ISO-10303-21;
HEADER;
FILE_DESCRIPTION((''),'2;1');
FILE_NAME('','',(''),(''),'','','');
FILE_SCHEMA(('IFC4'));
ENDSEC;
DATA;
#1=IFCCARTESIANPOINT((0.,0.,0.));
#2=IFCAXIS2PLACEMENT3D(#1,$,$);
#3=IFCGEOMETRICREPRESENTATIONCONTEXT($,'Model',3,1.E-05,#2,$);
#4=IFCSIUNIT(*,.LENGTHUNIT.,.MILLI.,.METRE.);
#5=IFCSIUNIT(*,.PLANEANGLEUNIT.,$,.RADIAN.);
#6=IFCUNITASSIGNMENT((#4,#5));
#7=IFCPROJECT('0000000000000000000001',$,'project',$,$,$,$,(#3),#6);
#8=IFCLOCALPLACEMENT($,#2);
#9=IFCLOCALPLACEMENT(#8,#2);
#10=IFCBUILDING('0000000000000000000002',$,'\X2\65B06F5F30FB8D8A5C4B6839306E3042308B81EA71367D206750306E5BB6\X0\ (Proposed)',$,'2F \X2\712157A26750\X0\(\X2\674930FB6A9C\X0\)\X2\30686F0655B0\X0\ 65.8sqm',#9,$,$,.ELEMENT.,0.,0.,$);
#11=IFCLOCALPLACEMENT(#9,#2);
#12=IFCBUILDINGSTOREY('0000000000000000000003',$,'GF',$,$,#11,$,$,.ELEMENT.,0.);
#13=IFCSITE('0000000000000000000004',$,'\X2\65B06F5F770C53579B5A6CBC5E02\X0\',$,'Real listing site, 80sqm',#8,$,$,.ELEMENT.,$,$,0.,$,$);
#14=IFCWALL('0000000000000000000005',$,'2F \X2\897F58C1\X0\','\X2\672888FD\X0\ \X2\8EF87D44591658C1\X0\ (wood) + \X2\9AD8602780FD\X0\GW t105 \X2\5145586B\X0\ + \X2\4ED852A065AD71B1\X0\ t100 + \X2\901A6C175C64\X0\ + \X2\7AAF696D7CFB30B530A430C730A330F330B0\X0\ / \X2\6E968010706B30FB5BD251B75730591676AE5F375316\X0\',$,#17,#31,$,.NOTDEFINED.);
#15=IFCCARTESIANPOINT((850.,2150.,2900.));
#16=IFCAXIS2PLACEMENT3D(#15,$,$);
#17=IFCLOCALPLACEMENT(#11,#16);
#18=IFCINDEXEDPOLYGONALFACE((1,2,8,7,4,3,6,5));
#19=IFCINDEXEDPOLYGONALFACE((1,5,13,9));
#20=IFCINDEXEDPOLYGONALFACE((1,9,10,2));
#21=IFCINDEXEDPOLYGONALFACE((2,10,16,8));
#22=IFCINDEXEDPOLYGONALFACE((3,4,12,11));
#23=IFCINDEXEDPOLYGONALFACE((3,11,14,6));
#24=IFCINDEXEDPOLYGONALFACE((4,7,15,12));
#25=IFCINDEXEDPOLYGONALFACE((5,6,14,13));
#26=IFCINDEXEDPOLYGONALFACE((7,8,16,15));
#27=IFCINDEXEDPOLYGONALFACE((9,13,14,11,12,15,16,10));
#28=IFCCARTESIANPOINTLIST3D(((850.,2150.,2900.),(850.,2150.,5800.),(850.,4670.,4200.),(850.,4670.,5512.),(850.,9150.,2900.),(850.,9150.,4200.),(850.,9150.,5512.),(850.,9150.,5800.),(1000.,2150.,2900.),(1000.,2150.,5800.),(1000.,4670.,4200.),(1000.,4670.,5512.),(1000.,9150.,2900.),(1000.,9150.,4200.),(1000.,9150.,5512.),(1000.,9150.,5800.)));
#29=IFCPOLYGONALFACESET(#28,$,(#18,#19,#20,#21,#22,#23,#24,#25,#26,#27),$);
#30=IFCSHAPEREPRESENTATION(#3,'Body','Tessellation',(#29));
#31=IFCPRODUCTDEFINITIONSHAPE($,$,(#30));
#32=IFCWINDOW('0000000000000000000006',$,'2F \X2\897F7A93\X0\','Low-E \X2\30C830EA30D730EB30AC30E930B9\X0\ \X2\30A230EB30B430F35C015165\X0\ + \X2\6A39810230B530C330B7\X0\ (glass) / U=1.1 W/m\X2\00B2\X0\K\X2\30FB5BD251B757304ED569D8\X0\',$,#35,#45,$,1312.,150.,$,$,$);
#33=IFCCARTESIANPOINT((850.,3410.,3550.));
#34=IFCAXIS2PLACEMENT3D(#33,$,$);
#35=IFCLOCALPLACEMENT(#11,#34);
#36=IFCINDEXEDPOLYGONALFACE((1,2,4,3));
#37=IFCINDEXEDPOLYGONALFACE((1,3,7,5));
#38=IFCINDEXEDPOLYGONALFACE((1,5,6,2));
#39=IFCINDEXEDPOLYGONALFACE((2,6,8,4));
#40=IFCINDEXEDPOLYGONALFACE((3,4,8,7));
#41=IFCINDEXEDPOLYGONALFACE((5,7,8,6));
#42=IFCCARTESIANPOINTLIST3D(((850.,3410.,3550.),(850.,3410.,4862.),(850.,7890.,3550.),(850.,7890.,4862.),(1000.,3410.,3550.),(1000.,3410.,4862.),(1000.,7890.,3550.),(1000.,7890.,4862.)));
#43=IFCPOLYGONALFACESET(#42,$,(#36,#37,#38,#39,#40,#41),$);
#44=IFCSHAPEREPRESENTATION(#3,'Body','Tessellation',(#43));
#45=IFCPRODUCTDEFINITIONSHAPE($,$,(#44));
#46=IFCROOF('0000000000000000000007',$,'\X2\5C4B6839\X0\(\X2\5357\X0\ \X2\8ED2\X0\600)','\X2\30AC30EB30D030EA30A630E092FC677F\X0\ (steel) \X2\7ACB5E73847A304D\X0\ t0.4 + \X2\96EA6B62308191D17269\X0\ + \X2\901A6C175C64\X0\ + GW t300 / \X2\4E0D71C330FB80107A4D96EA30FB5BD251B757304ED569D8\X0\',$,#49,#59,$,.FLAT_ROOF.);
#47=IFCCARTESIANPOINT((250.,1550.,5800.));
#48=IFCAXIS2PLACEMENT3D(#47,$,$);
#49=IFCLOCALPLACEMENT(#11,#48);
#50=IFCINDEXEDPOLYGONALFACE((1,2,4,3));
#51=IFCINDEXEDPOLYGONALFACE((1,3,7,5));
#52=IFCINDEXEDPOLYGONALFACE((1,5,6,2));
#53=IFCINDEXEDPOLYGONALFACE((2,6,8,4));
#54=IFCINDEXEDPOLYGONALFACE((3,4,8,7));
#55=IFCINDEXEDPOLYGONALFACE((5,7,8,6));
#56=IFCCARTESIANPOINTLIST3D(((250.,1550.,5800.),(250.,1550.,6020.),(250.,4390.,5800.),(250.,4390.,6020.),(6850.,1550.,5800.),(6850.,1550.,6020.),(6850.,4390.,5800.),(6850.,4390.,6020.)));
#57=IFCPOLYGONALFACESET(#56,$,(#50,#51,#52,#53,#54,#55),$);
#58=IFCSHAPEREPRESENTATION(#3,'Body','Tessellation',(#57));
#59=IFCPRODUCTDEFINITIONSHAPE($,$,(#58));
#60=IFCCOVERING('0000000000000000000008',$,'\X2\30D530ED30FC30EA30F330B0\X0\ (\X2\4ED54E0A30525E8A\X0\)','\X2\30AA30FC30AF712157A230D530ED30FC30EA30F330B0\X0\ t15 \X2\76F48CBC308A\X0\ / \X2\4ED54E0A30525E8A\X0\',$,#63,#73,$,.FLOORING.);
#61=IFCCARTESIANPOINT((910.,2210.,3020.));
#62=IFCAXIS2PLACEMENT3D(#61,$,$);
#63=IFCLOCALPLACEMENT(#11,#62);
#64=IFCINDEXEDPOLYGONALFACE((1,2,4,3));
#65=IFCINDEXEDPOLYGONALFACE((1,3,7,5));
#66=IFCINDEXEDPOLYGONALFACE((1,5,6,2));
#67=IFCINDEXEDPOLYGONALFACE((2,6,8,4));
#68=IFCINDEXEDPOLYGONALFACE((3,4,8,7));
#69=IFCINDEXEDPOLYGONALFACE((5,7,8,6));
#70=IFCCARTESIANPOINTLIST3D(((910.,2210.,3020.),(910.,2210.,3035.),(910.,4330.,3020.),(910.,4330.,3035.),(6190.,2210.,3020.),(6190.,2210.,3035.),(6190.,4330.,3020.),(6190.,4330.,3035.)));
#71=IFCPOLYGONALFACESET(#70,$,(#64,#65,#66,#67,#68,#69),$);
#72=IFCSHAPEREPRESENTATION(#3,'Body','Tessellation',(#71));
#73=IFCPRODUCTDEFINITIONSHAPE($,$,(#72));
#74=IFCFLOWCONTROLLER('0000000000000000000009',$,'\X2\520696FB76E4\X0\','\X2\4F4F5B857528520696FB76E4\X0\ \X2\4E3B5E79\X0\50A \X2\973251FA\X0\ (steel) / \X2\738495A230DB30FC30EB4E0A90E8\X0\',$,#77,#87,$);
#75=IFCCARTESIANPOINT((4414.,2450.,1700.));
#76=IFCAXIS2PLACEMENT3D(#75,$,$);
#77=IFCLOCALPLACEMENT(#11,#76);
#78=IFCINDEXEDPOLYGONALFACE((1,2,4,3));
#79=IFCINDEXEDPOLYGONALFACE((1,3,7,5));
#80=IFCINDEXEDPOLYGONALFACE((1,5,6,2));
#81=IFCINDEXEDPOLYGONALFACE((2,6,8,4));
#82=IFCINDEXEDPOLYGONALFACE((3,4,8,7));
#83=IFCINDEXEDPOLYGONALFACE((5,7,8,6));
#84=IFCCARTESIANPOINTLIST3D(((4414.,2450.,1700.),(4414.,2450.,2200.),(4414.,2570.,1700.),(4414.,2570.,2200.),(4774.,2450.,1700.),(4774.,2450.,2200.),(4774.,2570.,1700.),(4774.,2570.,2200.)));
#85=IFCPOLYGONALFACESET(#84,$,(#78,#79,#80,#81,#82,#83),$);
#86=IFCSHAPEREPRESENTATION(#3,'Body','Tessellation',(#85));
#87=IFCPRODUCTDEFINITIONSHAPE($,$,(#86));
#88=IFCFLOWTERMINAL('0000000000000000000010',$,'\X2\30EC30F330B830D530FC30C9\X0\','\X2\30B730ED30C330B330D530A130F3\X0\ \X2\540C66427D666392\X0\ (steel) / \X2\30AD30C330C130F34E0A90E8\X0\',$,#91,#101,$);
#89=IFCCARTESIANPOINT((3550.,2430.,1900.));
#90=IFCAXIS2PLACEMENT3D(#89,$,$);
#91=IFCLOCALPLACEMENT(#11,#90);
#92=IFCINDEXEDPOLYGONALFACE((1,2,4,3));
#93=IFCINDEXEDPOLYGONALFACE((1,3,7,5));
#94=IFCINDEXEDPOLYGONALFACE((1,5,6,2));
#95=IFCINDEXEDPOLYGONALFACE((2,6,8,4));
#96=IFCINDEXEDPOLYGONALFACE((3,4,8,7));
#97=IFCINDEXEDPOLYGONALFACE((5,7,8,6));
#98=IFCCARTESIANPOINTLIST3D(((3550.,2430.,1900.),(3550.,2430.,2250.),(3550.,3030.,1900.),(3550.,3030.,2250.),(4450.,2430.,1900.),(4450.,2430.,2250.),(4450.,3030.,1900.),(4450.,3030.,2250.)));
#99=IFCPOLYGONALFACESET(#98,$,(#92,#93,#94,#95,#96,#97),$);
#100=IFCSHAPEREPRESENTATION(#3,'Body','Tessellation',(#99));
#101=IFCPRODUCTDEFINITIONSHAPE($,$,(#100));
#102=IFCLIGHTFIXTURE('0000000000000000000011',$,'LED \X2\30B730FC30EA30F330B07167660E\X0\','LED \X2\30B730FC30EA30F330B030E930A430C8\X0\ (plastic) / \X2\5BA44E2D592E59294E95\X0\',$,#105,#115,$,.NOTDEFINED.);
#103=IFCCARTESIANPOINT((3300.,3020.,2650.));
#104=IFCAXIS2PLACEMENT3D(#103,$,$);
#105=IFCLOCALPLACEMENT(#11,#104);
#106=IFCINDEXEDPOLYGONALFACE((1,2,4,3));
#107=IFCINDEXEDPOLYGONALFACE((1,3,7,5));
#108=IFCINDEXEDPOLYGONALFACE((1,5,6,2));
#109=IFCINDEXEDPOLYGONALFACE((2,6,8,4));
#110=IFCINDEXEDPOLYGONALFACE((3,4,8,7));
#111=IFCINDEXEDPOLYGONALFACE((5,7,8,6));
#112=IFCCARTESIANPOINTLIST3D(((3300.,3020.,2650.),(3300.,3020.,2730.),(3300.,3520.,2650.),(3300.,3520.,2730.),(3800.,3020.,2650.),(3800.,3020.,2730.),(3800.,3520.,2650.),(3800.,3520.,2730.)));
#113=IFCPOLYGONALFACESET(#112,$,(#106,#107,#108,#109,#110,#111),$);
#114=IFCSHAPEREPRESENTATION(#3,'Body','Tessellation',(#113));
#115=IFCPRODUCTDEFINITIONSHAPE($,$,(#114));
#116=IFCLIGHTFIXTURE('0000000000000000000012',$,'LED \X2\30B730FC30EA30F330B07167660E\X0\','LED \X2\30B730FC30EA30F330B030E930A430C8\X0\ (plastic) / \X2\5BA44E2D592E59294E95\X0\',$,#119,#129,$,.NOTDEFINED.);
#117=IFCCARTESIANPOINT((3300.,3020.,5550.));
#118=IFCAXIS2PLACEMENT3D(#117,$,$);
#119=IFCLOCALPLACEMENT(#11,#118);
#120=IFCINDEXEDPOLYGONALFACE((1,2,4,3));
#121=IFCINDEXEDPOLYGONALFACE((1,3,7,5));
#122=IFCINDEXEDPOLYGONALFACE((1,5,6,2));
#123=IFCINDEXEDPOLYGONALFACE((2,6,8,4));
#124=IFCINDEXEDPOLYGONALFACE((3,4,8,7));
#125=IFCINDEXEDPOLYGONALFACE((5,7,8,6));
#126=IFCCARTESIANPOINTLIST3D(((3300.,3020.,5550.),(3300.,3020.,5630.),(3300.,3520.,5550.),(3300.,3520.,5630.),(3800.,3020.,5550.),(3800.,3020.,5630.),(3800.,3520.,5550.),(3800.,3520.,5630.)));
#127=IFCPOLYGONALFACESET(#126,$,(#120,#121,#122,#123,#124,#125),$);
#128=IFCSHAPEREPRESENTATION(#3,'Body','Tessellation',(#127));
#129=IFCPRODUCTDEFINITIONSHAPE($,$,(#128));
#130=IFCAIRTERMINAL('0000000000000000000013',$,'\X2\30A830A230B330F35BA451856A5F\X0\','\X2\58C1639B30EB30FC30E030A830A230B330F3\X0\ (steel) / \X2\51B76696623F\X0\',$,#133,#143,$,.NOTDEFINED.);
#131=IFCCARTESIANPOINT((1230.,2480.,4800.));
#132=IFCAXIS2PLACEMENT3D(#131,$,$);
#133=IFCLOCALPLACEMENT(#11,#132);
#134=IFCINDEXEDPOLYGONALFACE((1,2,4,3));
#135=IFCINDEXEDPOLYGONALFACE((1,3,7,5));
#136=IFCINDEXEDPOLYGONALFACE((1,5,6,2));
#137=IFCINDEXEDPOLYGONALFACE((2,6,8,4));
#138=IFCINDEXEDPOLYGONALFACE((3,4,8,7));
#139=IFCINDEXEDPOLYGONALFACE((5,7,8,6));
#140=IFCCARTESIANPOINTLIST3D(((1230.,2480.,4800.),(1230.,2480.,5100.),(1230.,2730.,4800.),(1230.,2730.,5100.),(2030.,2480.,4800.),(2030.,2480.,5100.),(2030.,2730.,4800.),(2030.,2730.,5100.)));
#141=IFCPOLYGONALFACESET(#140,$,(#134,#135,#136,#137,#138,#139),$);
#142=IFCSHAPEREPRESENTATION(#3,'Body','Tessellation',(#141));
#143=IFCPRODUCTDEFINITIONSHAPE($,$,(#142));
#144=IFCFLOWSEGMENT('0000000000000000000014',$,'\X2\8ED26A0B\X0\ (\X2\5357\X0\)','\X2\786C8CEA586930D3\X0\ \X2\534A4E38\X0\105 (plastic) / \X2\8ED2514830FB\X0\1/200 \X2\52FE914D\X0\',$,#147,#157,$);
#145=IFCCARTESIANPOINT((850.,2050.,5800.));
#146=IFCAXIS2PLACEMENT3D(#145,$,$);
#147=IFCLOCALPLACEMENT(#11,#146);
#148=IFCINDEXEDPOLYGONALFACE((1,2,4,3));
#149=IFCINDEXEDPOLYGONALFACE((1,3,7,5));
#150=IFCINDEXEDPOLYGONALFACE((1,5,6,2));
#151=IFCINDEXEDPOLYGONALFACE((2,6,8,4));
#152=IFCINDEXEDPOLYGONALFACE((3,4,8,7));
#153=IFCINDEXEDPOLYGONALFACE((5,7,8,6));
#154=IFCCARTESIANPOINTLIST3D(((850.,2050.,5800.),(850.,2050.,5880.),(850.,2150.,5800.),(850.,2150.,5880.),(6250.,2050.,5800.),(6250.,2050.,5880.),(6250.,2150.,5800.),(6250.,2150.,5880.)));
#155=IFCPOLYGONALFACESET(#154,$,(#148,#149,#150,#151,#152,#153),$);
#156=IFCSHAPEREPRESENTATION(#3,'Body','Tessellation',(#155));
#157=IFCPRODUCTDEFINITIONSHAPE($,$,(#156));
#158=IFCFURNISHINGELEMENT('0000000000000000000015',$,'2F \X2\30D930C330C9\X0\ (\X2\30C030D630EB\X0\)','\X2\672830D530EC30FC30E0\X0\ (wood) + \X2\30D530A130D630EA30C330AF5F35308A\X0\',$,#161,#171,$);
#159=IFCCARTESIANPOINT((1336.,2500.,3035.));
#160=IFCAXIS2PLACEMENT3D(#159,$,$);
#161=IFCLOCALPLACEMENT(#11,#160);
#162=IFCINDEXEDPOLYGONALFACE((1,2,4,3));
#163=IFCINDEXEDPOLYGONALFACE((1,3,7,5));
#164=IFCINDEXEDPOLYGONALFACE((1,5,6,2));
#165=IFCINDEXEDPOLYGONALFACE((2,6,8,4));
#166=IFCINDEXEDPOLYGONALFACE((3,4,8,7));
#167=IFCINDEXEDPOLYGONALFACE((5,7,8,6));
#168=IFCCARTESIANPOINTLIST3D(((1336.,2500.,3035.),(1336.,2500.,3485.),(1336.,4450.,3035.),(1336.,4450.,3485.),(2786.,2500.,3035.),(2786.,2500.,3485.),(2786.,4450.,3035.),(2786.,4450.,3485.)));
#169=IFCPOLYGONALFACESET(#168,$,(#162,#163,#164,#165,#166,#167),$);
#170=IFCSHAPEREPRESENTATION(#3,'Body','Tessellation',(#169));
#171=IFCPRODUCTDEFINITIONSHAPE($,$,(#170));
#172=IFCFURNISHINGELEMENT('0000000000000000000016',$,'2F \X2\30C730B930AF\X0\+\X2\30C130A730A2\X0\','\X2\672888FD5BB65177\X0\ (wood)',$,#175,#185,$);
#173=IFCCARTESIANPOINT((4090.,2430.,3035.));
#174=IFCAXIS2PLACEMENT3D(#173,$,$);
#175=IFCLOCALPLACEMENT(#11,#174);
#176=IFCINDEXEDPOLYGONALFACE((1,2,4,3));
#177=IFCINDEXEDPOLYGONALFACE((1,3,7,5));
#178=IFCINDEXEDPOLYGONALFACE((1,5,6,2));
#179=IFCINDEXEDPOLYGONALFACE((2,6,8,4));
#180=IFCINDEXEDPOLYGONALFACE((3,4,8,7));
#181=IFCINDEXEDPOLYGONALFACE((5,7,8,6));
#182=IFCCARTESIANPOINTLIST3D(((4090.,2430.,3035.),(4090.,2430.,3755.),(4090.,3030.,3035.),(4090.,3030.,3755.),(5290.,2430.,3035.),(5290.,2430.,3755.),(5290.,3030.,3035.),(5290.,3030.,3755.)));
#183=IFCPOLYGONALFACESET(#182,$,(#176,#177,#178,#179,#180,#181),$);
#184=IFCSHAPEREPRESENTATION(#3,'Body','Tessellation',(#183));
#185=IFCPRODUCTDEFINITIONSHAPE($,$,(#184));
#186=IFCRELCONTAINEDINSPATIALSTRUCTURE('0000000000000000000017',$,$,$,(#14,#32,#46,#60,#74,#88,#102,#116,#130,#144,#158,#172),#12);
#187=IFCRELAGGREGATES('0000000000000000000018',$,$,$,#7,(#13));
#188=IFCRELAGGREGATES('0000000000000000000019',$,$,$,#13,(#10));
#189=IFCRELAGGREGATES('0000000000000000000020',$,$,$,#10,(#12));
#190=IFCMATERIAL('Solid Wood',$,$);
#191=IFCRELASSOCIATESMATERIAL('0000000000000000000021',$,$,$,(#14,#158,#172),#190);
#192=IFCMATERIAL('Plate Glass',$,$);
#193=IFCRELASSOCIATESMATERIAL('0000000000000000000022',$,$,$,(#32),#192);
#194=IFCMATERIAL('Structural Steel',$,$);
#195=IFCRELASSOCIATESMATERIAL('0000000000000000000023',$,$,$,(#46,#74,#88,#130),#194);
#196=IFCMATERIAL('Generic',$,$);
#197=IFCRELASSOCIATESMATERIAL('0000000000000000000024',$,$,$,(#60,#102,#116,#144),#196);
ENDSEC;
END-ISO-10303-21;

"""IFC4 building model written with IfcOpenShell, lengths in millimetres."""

from ifc_helpers import new_model, si_unit, frame, frame_2d, origin, place, context, project, spatial, rectangle, extrude, material, element, fill, save


model = new_model("IFC4")

# Units and contexts
model_context = context("Model", 3, precision=1e-05, world=origin())
ifc_project = project(units=[si_unit("LENGTHUNIT", "METRE", prefix="MILLI"), si_unit("PLANEANGLEUNIT", "RADIAN")], contexts=[model_context])

# Site, building, storey
site_placement = place(None, origin())
site = spatial("IfcSite", under=ifc_project, at=site_placement, Name="新潟県南魚沼市", ObjectType="Real listing site, 80sqm", CompositionType="ELEMENT", RefElevation=0.0)
building_placement = place(site_placement, origin())
building = spatial("IfcBuilding", under=site, at=building_placement, Name="新潟・越屋根のある自然素材の家 (Proposed)", ObjectType="2F 無垢材(杉・檜)と漆喰 65.8sqm", CompositionType="ELEMENT", ElevationOfRefHeight=0.0, ElevationOfTerrain=0.0)
storey_placement = place(building_placement, origin())
storey = spatial("IfcBuildingStorey", under=building, at=storey_placement, Name="GF", CompositionType="ELEMENT", Elevation=0.0)

# Shared definitions
ifc_material_1 = material(Name="Solid Wood")

# Wall, opening, window
ifc_material_2 = material(Name="Plate Glass")
wall_1_placement = place(storey_placement, frame((850.0, 2150.0, 2900.0)))
wall_1 = element("IfcWall", 1, at=wall_1_placement, inside=storey, material=ifc_material_1, Name="2F 西壁", Description="木製 軸組外壁 (wood) + 高性能GW t105 充填 + 付加断熱 t100 + 通気層 + 窯業系サイディング / 準耐火・寒冷地外皮強化", PredefinedType="NOTDEFINED", context=model_context, shape_type="SweptSolid", body=[
    extrude(rectangle(XDim=150.0, YDim=7000.0, at=frame_2d((75.0, 3500.0))), frame((850.0, 2150.0, 2900.0)), (0.0, 0.0, 1.0), 2900.0),
])
opening_1_placement = place(storey_placement, frame((850.0, 3410.0, 3550.0)))
opening_1 = element("IfcOpeningElement", 2, at=opening_1_placement, cuts=wall_1, PredefinedType="NOTDEFINED", context=model_context, shape_type="SweptSolid", body=[
    extrude(rectangle(XDim=150.0, YDim=4480.0, at=frame_2d((75.0, 2240.0))), frame((850.0, 3410.0, 3550.0)), (0.0, 0.0, 1.0), 1312.0),
])
window_1_placement = place(storey_placement, frame((850.0, 3410.0, 3550.0)))
window_1 = element("IfcWindow", 3, at=window_1_placement, inside=storey, material=ifc_material_2, Name="2F 西窓", Description="Low-E トリプルガラス アルゴン封入 + 樹脂サッシ (glass) / U=1.1 W/m²K・寒冷地仕様", OverallHeight=1312.0, OverallWidth=150.0, context=model_context, shape_type="SweptSolid", body=[
    extrude(rectangle(XDim=150.0, YDim=4480.0, at=frame_2d((75.0, 2240.0))), frame((850.0, 3410.0, 3550.0)), (0.0, 0.0, 1.0), 1312.0),
])
fill(opening_1, window_1)

# Roof
ifc_material_3 = material(Name="Structural Steel")
for number, where, name in (
    (4, (250.0, 1550.0, 5800.0), "屋根(南 軒600)"),
):
    element("IfcRoof", number, at=place(storey_placement, frame(where)), inside=storey, material=ifc_material_3, Name=name, Description="ガルバリウム鋼板 (steel) 立平葺き t0.4 + 雪止め金物 + 通気層 + GW t300 / 不燃・耐積雪・寒冷地仕様", PredefinedType="FLAT_ROOF", context=model_context, shape_type="SweptSolid", body=[
        extrude(rectangle(XDim=6600.0, YDim=2840.0, at=frame_2d((3300.0, 1420.0))), frame((250.0, 1550.0, 5800.0)), (0.0, 0.0, 1.0), 220.0),
    ])

# Covering
ifc_material_4 = material(Name="Generic")
covering_placement = place(storey_placement, frame((910.0, 2210.0, 3020.0)))
element("IfcCovering", 5, at=covering_placement, inside=storey, material=ifc_material_4, Name="フローリング (仕上げ床)", Description="オーク無垢フローリング t15 直貼り / 仕上げ床", PredefinedType="FLOORING", context=model_context, shape_type="SweptSolid", body=[
    extrude(rectangle(XDim=5280.0, YDim=2120.0, at=frame_2d((2640.0, 1060.0))), frame((910.0, 2210.0, 3020.0)), (0.0, 0.0, 1.0), 15.0),
])

# Flow controller
flow_controller_placement = place(storey_placement, frame((4414.0, 2450.0, 1700.0)))
element("IfcFlowController", 6, at=flow_controller_placement, inside=storey, material=ifc_material_3, Name="分電盤", Description="住宅用分電盤 主幹50A 露出 (steel) / 玄関ホール上部", context=model_context, shape_type="SweptSolid", body=[
    extrude(rectangle(XDim=360.0, YDim=120.0, at=frame_2d((180.0, 60.0))), frame((4414.0, 2450.0, 1700.0)), (0.0, 0.0, 1.0), 500.0),
])

# Flow terminal
flow_terminal_placement = place(storey_placement, frame((3550.0, 2430.0, 1900.0)))
element("IfcFlowTerminal", 7, at=flow_terminal_placement, inside=storey, material=ifc_material_3, Name="レンジフード", Description="シロッコファン 同時給排 (steel) / キッチン上部", context=model_context, shape_type="SweptSolid", body=[
    extrude(rectangle(XDim=900.0, YDim=600.0, at=frame_2d((450.0, 300.0))), frame((3550.0, 2430.0, 1900.0)), (0.0, 0.0, 1.0), 350.0),
])

# Light fixtures
light_fixture_1_placement = place(storey_placement, frame((3300.0, 3020.0, 2650.0)))
element("IfcLightFixture", 8, at=light_fixture_1_placement, inside=storey, material=ifc_material_4, Name="LED シーリング照明", Description="LED シーリングライト (plastic) / 室中央天井", PredefinedType="NOTDEFINED", context=model_context, shape_type="SweptSolid", body=[
    extrude(rectangle(XDim=500.0, YDim=500.0, at=frame_2d((250.0, 250.0))), frame((3300.0, 3020.0, 2650.0)), (0.0, 0.0, 1.0), 80.0),
])
light_fixture_2_placement = place(storey_placement, frame((3300.0, 3020.0, 5550.0)))
element("IfcLightFixture", 9, at=light_fixture_2_placement, inside=storey, material=ifc_material_4, Name="LED シーリング照明", Description="LED シーリングライト (plastic) / 室中央天井", PredefinedType="NOTDEFINED", context=model_context, shape_type="SweptSolid", body=[
    extrude(rectangle(XDim=500.0, YDim=500.0, at=frame_2d((250.0, 250.0))), frame((3300.0, 3020.0, 5550.0)), (0.0, 0.0, 1.0), 80.0),
])

# Air terminal
air_terminal_placement = place(storey_placement, frame((1230.0, 2480.0, 4800.0)))
element("IfcAirTerminal", 10, at=air_terminal_placement, inside=storey, material=ifc_material_3, Name="エアコン室内機", Description="壁掛ルームエアコン (steel) / 冷暖房", PredefinedType="NOTDEFINED", context=model_context, shape_type="SweptSolid", body=[
    extrude(rectangle(XDim=800.0, YDim=250.0, at=frame_2d((400.0, 125.0))), frame((1230.0, 2480.0, 4800.0)), (0.0, 0.0, 1.0), 300.0),
])

# Flow segment
flow_segment_placement = place(storey_placement, frame((850.0, 2050.0, 5800.0)))
element("IfcFlowSegment", 11, at=flow_segment_placement, inside=storey, material=ifc_material_4, Name="軒樋 (南)", Description="硬質塩ビ 半丸105 (plastic) / 軒先・1/200 勾配", context=model_context, shape_type="SweptSolid", body=[
    extrude(rectangle(XDim=5400.0, YDim=100.0, at=frame_2d((2700.0, 50.0))), frame((850.0, 2050.0, 5800.0)), (0.0, 0.0, 1.0), 80.0),
])

# Furnishing elements
furnishing_1_placement = place(storey_placement, frame((1336.0, 2500.0, 3035.0)))
element("IfcFurnishingElement", 12, at=furnishing_1_placement, inside=storey, material=ifc_material_1, Name="2F ベッド (ダブル)", Description="木フレーム (wood) + ファブリック張り", context=model_context, shape_type="SweptSolid", body=[
    extrude(rectangle(XDim=1450.0, YDim=1950.0, at=frame_2d((725.0, 975.0))), frame((1336.0, 2500.0, 3035.0)), (0.0, 0.0, 1.0), 450.0),
])
furnishing_2_placement = place(storey_placement, frame((4090.0, 2430.0, 3035.0)))
element("IfcFurnishingElement", 13, at=furnishing_2_placement, inside=storey, material=ifc_material_1, Name="2F デスク+チェア", Description="木製家具 (wood)", context=model_context, shape_type="SweptSolid", body=[
    extrude(rectangle(XDim=1200.0, YDim=600.0, at=frame_2d((600.0, 300.0))), frame((4090.0, 2430.0, 3035.0)), (0.0, 0.0, 1.0), 720.0),
])

save(model, "model.ifc")
